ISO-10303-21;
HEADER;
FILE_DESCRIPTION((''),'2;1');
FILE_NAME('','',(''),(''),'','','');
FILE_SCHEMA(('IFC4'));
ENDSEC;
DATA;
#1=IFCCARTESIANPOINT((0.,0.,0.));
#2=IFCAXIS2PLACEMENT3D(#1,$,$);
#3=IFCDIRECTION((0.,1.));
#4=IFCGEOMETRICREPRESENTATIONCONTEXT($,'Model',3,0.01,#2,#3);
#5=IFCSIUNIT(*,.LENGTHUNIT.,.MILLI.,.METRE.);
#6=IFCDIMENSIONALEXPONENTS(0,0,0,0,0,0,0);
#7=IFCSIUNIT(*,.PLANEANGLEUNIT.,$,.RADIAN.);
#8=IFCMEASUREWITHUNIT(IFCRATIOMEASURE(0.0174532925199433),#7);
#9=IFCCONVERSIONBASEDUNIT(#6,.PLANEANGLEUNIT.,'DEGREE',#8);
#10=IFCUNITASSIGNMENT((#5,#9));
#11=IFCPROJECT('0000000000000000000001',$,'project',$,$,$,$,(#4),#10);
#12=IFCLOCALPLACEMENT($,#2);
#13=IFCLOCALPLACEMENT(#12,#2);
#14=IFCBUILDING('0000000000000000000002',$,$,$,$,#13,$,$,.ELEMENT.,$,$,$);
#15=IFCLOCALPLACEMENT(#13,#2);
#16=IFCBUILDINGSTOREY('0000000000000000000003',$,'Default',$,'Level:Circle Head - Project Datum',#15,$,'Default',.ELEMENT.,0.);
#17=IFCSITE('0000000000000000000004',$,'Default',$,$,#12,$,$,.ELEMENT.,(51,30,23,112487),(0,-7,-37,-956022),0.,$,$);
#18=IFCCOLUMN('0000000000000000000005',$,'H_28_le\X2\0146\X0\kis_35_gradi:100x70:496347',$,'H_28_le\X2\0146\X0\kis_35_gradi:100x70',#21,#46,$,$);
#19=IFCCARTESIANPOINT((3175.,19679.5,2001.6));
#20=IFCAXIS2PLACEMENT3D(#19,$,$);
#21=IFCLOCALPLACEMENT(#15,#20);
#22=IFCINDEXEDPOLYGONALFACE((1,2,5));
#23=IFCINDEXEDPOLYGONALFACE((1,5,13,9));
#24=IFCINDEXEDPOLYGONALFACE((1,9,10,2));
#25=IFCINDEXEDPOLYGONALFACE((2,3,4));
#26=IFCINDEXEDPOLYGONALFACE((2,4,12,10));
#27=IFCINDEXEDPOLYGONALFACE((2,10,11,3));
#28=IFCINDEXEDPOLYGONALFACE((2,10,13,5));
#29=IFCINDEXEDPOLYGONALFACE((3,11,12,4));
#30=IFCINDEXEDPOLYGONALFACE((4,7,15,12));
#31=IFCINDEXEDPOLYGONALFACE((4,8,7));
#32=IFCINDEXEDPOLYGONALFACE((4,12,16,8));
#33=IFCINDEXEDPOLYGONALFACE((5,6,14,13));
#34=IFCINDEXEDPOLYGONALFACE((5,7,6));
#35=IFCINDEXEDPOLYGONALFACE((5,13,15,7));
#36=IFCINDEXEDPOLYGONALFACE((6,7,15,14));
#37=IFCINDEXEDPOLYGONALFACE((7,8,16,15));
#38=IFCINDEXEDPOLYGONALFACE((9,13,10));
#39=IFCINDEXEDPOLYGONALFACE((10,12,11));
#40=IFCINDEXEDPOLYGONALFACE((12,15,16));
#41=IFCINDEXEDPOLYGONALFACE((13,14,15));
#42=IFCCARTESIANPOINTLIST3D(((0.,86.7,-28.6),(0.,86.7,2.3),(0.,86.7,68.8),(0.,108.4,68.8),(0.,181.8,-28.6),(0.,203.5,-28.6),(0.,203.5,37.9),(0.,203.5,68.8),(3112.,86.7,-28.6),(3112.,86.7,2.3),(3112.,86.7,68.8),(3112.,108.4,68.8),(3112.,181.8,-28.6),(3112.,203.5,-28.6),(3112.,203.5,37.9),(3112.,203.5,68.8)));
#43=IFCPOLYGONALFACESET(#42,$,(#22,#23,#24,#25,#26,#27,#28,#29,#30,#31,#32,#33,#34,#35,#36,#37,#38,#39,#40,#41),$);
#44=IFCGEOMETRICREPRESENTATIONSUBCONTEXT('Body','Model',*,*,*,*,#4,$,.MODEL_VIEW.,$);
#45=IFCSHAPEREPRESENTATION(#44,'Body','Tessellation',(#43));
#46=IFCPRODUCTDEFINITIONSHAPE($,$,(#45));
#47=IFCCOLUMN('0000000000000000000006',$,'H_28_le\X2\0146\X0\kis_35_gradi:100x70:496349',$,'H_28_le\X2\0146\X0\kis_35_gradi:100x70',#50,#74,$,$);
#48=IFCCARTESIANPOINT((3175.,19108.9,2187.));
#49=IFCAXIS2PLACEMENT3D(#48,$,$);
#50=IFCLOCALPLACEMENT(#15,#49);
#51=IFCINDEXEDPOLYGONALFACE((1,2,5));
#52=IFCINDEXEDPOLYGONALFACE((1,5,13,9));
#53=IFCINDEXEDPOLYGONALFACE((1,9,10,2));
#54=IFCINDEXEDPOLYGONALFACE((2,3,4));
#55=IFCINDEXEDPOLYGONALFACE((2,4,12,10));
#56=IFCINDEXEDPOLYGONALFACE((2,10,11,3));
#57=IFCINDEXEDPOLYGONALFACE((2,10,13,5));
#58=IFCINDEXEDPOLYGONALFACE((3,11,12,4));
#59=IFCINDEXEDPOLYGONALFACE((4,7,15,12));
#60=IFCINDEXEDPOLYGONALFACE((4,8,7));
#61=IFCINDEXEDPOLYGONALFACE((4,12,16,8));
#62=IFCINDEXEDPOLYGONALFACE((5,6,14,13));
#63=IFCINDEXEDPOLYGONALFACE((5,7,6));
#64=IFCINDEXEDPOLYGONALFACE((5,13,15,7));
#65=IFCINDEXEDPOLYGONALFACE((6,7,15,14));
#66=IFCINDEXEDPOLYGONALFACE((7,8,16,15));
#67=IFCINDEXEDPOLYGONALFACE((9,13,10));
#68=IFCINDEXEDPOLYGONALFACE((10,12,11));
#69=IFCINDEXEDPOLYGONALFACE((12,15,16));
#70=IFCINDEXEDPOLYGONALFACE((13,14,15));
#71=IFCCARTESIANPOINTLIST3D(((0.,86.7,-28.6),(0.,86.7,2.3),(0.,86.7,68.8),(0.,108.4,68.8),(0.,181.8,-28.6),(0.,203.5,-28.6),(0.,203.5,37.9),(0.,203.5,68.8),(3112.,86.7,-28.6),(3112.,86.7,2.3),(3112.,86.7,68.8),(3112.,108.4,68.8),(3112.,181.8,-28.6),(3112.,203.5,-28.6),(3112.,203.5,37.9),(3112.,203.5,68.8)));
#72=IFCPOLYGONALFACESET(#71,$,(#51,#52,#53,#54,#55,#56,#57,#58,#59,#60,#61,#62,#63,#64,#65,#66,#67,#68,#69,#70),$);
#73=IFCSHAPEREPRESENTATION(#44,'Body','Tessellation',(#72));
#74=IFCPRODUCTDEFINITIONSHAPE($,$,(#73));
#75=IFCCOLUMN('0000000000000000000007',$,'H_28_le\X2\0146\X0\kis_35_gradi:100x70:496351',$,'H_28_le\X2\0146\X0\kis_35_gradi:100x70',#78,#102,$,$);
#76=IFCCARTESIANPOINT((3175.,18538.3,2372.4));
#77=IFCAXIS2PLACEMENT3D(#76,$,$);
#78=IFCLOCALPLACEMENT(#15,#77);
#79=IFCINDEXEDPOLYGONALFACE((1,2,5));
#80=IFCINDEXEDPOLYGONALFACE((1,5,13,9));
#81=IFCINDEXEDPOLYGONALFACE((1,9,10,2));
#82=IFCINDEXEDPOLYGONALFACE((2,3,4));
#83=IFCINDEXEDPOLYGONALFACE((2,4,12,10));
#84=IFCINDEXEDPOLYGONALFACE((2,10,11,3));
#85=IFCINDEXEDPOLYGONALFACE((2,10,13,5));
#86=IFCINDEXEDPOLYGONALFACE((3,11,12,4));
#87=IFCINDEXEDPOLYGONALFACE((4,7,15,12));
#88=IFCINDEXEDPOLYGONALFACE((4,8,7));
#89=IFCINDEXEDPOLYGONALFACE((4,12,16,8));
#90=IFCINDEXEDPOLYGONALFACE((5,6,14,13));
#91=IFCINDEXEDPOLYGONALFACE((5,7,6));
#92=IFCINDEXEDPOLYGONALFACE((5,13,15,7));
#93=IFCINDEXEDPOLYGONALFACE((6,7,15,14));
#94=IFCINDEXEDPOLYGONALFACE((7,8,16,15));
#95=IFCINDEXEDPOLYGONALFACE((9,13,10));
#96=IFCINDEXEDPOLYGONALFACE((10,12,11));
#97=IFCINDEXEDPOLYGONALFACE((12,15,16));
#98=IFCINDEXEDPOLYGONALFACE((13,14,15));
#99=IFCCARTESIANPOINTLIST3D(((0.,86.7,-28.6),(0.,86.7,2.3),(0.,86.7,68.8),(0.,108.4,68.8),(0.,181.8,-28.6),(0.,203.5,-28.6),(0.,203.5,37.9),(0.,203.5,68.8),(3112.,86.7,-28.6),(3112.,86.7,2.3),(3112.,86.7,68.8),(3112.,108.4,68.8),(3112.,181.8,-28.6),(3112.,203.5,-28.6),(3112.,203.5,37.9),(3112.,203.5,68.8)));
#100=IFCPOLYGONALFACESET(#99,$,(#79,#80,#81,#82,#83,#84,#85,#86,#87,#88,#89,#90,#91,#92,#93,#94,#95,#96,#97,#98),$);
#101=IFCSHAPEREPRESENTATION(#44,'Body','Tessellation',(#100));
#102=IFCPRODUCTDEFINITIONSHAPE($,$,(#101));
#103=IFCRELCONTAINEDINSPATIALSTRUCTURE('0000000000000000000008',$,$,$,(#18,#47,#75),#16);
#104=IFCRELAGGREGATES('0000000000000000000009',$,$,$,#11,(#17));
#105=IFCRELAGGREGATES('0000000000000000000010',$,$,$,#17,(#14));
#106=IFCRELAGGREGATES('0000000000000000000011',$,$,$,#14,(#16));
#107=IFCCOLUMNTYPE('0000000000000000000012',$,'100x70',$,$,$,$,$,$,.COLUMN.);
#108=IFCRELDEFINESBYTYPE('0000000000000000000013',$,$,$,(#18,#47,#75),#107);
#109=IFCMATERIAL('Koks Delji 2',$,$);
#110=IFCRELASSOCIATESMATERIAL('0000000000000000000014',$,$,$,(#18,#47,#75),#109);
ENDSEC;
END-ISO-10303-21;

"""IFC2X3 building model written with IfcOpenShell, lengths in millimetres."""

from ifc_helpers import new_model, entity, si_unit, converted_unit, direction, frame, frame_2d, origin, origin_2d_with_axis, place, context, subcontext, project, spatial, rectangle, extrude, boolean, source, transform, mapped, material, type_object, type_shapes, element, save


model = new_model("IFC2X3")

# Units and contexts
model_context = context("Model", 3, precision=0.01, world=origin(), true_north=direction((0.0, 1.0)))
body_context = subcontext(model_context, "Body", "Model", "MODEL_VIEW")
ifc_project = project(units=[si_unit("LENGTHUNIT", "METRE", prefix="MILLI"), converted_unit("PLANEANGLEUNIT", "DEGREE", entity("IfcRatioMeasure", 0.0174532925199433), si_unit("PLANEANGLEUNIT", "RADIAN"), dimensions=[0, 0, 0, 0, 0, 0, 0])], contexts=[model_context])

# Site, building, storey
site_placement = place(None, origin())
site = spatial("IfcSite", under=ifc_project, at=site_placement, Name="Default", CompositionType="ELEMENT", RefLatitude=(51, 30, 23, 112487), RefLongitude=(0, -7, -37, -956022), RefElevation=0.0)
building_placement = place(site_placement, origin())
building = spatial("IfcBuilding", under=site, at=building_placement, CompositionType="ELEMENT")
storey_placement = place(building_placement, origin())
storey = spatial("IfcBuildingStorey", under=building, at=storey_placement, Name="Default", ObjectType="Level:Circle Head - Project Datum", LongName="Default", CompositionType="ELEMENT", Elevation=0.0)

# Columns
ifc_material_1 = material(Name="Koks Delji 2")
column_type = type_object("IfcColumnType", Name="100x70", PredefinedType="COLUMN")
shared_shape_1 = source(origin(), body_context, "Body", "CSG", [
    boolean("DIFFERENCE", extrude(rectangle(XDim=3112.0, YDim=116.7, at=origin_2d_with_axis()), frame((1556.0, 145.1, -28.6)), (0.0, 0.0, 1.0), 97.5), extrude(rectangle(XDim=70.0, YDim=100.0, at=frame_2d((0.0, 0.0), x_axis=(0.0, 1.0))), frame((3112.0, 145.1, 20.1), z_axis=(1.0, 0.0, 0.0), x_axis=(0.0, 0.951057, -0.309017)), (0.0, 0.0, -1.0), 3112.0)),
])
type_shapes(column_type, [shared_shape_1])
for number, where, name in (
    (1, (3175.0, 19679.5, 2001.6), "H_28_leņkis_35_gradi:100x70:496347"),
    (2, (3175.0, 19108.9, 2187.0), "H_28_leņkis_35_gradi:100x70:496349"),
    (3, (3175.0, 18538.3, 2372.4), "H_28_leņkis_35_gradi:100x70:496351"),
):
    element("IfcColumn", number, at=place(storey_placement, frame(where)), inside=storey, type_object=column_type, material=ifc_material_1, Name=name, ObjectType="H_28_leņkis_35_gradi:100x70", context=body_context, shape_type="MappedRepresentation", body=[
        mapped(shared_shape_1, transform((0.0, 0.0, 0.0), scale=1.0)),
    ])

save(model, "model.ifc")
